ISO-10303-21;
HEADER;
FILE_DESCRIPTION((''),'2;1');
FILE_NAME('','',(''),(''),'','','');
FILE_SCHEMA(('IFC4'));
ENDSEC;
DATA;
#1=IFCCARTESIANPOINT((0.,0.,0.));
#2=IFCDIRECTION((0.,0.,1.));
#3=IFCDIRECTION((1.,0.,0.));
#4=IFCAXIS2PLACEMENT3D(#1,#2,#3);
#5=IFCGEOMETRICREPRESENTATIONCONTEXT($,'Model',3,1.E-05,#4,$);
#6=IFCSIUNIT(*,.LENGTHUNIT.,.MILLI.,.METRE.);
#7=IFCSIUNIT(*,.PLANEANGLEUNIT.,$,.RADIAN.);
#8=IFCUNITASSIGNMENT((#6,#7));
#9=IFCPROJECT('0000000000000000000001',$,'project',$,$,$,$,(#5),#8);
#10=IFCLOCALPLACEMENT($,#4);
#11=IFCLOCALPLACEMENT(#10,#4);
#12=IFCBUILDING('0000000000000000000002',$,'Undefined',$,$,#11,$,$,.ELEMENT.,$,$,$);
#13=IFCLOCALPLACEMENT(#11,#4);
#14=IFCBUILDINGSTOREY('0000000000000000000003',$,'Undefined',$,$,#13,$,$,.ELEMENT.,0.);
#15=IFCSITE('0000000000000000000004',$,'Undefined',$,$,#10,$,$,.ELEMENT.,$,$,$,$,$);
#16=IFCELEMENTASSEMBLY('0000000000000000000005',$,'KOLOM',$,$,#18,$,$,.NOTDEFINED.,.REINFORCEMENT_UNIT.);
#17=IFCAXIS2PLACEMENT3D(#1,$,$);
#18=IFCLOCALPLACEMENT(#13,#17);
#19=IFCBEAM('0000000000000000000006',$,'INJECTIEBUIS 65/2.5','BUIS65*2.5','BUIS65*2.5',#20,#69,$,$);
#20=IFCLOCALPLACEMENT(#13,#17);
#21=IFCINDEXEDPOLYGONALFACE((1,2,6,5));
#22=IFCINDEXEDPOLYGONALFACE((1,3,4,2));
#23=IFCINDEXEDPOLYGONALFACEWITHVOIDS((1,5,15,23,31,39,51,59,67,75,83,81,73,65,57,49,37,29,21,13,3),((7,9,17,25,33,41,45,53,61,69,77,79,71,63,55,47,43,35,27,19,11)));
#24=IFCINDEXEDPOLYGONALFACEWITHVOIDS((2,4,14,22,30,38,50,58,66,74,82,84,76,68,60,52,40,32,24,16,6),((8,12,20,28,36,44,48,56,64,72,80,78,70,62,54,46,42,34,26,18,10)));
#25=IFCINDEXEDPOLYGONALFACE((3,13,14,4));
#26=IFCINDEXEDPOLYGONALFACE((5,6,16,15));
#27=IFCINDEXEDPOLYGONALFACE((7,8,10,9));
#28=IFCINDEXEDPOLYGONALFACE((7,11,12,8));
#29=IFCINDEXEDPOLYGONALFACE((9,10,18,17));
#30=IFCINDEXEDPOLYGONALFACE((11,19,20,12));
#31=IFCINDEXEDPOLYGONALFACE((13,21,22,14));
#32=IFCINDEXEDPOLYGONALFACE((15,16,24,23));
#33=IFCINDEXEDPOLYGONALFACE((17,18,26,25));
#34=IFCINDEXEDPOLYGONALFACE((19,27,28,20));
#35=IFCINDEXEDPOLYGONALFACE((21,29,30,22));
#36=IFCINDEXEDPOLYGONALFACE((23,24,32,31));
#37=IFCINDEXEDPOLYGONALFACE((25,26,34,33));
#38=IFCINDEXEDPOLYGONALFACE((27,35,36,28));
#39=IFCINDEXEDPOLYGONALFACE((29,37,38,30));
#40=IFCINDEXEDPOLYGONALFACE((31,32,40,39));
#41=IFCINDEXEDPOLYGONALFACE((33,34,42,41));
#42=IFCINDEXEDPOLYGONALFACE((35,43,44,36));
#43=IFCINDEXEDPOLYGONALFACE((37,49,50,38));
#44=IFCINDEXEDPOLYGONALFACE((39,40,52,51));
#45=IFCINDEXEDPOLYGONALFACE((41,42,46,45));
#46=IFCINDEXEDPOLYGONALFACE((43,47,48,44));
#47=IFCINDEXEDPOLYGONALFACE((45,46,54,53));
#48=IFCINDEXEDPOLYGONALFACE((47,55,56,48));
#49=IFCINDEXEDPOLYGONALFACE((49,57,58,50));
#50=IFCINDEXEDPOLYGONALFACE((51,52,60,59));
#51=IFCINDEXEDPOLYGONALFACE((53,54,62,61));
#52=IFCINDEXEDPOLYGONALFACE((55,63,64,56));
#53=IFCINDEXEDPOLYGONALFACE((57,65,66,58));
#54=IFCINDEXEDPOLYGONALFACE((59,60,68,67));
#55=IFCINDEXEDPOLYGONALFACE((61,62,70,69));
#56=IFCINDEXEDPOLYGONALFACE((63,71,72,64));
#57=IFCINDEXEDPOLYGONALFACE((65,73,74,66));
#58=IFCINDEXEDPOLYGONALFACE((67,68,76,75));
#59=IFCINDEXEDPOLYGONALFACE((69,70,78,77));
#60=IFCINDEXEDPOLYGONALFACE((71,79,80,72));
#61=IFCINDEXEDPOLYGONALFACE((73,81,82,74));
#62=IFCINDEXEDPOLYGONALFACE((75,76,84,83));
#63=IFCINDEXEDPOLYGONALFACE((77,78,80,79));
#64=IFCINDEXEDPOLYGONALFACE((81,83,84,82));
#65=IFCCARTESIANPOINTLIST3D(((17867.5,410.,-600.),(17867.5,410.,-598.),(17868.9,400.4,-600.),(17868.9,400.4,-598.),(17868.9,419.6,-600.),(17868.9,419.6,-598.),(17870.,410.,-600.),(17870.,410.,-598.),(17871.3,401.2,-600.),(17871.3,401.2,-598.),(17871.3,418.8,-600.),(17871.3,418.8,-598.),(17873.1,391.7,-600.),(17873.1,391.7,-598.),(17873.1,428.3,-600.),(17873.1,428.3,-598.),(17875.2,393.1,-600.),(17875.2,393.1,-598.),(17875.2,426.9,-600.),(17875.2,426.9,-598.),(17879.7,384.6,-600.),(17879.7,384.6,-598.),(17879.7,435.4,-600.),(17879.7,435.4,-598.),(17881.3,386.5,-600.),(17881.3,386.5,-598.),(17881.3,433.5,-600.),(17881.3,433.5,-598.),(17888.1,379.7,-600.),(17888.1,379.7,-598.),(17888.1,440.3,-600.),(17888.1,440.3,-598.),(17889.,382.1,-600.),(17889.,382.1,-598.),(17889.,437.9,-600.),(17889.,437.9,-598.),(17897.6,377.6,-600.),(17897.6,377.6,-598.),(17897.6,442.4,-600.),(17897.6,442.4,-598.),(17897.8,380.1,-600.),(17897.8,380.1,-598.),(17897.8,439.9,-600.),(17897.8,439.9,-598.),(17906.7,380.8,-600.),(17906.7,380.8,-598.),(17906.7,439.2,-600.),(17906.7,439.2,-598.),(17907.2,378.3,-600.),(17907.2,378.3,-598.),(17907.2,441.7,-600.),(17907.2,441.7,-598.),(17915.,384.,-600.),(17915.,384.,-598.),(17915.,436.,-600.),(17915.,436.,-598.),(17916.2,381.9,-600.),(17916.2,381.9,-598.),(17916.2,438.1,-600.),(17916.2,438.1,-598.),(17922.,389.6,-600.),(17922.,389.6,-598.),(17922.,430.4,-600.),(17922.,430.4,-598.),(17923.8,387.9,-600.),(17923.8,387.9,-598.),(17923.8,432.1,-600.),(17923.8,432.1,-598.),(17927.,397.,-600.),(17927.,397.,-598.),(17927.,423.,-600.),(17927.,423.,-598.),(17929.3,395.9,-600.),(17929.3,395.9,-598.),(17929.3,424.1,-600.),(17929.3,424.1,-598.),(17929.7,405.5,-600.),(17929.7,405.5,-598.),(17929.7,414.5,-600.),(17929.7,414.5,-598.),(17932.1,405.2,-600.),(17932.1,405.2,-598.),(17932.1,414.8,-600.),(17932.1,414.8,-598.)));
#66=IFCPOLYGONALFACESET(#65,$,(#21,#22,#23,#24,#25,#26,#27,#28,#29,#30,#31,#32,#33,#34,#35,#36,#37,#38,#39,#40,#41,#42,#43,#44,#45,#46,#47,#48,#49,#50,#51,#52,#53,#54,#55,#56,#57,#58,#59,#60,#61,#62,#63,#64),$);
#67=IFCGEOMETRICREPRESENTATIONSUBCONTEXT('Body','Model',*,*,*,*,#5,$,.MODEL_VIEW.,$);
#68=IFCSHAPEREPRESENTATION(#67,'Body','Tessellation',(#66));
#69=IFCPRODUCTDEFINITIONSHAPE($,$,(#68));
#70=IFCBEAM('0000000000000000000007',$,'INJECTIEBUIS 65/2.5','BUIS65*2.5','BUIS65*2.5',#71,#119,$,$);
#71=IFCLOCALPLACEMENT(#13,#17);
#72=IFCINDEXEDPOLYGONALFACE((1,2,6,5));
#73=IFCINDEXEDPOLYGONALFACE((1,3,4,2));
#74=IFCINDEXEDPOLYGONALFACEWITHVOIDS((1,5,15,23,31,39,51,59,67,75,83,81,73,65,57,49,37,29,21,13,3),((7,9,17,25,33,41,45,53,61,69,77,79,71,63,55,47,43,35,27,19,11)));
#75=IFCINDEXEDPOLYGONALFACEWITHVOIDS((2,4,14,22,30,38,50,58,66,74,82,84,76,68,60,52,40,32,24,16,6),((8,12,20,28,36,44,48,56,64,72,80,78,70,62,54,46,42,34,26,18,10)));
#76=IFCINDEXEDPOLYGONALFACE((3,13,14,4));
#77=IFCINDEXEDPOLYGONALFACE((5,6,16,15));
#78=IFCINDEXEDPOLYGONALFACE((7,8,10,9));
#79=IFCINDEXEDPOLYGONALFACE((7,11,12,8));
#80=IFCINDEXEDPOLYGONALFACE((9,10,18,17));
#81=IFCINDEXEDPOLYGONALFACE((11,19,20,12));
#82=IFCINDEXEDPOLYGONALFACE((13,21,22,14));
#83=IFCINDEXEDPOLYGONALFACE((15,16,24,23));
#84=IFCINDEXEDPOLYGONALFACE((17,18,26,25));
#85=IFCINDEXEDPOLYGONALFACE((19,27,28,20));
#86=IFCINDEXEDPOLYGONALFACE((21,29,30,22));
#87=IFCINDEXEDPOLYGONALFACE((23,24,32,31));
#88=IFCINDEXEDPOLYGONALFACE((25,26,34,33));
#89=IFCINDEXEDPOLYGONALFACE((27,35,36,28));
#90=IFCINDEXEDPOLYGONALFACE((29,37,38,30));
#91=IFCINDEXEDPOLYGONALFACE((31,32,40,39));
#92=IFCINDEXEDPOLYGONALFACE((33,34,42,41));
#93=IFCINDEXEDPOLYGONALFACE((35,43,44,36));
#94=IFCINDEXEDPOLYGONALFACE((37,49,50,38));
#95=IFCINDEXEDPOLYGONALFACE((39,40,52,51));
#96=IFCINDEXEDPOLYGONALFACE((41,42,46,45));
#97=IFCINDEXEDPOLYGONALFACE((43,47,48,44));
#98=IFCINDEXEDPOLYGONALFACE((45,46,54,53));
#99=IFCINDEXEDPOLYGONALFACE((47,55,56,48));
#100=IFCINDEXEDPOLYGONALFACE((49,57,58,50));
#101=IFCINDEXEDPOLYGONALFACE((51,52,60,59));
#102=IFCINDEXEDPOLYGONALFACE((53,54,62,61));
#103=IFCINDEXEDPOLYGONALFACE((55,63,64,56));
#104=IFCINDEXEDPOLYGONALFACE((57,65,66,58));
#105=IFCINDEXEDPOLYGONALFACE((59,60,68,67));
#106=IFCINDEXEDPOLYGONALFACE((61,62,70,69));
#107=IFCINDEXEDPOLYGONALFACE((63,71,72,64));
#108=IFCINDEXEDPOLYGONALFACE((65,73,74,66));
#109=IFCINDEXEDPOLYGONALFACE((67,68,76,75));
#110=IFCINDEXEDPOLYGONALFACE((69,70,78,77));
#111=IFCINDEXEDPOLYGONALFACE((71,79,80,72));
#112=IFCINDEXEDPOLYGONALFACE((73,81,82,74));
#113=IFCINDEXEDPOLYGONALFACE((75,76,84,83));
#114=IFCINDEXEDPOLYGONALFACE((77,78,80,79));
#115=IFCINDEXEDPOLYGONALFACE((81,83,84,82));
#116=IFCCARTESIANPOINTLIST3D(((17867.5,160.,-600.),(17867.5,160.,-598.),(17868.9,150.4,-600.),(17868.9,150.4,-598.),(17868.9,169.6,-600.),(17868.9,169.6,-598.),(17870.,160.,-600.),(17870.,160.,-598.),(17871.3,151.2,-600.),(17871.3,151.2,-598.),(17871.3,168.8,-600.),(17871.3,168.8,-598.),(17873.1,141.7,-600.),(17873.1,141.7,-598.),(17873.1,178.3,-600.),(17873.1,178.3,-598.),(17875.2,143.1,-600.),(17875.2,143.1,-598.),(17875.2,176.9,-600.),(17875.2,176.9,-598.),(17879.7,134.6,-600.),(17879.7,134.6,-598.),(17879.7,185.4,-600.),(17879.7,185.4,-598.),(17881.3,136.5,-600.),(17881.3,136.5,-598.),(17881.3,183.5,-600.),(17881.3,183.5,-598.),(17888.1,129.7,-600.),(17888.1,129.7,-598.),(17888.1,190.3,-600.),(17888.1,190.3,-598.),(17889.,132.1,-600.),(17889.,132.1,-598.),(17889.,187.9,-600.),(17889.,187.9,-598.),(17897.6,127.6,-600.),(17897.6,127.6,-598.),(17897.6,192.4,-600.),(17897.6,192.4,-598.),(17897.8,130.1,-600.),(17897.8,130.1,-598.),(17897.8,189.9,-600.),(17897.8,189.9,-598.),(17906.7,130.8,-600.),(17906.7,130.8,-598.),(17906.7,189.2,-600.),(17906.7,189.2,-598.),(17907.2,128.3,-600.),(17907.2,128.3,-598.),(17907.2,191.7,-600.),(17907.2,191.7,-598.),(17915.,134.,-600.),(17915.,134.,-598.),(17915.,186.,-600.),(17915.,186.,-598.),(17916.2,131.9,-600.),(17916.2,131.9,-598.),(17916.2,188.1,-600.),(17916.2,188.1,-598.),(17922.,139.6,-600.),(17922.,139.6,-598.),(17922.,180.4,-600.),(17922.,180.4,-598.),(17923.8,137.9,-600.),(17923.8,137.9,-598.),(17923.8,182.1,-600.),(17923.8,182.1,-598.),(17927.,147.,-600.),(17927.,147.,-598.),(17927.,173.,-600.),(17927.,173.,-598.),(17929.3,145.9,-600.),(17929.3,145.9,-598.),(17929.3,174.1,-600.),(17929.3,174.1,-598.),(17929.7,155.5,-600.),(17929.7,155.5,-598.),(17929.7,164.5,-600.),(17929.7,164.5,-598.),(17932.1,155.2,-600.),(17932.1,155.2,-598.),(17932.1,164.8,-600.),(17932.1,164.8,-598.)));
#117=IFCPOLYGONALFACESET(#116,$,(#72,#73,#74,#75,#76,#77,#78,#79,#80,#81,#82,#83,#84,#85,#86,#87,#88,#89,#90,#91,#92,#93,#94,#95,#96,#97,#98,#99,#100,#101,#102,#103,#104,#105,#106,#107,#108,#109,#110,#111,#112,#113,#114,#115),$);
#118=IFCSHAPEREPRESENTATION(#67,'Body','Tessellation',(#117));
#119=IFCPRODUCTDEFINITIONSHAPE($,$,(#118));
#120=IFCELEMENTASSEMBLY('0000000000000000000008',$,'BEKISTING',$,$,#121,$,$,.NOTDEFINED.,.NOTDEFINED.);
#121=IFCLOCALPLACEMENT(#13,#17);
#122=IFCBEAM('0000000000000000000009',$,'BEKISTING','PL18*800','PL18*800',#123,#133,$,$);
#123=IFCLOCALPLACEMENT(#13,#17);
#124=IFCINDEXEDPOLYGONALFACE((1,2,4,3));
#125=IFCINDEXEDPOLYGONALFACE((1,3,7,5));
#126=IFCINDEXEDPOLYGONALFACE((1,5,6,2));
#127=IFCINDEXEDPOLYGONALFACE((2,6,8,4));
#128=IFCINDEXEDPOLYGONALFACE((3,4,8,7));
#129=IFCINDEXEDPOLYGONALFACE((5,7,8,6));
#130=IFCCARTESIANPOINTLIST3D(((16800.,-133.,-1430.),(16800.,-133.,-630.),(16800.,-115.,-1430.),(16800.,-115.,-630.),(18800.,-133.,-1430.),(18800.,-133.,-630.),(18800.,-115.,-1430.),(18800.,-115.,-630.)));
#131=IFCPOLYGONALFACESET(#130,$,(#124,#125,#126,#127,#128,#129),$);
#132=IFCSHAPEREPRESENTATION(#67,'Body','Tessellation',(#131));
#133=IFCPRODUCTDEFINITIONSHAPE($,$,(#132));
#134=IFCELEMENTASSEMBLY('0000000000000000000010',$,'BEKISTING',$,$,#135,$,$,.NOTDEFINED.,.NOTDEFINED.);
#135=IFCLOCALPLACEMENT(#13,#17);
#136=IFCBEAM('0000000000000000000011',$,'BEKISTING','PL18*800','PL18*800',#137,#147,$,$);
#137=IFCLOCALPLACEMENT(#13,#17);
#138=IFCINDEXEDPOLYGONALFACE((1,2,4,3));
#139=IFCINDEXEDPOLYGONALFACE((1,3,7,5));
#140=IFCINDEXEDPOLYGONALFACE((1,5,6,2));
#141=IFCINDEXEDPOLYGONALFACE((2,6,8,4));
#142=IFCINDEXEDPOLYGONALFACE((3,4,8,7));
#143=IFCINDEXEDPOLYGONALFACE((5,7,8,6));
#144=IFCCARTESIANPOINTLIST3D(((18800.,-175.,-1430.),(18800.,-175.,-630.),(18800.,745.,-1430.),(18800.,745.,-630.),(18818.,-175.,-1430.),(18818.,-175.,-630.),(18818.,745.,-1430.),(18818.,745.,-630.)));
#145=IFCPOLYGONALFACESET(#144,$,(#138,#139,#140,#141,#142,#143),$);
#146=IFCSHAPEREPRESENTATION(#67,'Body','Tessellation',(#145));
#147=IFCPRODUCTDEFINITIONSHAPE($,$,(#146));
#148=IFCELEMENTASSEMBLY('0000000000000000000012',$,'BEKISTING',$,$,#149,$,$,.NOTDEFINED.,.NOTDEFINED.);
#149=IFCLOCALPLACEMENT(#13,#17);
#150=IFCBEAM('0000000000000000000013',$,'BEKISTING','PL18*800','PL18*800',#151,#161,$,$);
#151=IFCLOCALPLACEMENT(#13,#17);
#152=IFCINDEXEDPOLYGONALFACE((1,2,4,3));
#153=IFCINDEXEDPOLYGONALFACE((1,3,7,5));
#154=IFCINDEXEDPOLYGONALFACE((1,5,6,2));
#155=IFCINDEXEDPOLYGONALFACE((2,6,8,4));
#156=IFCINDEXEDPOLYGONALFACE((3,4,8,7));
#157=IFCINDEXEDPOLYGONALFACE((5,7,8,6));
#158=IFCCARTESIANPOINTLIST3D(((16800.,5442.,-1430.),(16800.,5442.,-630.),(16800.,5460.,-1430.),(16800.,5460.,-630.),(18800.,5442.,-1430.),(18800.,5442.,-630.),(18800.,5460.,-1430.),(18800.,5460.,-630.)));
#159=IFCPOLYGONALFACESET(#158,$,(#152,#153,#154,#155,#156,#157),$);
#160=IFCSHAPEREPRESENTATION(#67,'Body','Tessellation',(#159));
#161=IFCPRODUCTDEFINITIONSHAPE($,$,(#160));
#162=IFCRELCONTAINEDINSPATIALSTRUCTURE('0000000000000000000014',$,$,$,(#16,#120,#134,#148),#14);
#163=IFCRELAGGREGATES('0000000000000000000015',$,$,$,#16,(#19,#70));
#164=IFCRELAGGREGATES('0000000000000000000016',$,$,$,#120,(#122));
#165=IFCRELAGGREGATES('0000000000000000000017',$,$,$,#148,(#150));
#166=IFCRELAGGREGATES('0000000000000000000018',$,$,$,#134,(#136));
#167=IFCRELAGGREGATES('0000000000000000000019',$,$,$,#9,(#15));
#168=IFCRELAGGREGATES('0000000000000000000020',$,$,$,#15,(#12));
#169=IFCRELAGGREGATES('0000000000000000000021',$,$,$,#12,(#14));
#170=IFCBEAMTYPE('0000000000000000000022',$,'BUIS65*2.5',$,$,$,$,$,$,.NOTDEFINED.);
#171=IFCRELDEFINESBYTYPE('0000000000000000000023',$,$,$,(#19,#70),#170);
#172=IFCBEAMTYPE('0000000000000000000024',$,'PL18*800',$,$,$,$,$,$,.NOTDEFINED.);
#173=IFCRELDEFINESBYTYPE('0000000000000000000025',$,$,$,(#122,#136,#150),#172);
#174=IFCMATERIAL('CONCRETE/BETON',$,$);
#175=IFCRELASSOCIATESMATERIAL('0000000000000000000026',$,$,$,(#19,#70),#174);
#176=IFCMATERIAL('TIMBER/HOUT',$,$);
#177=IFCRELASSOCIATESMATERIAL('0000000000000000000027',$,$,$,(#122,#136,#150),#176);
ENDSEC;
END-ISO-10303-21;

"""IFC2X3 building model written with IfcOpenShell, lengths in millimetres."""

from ifc_helpers import new_model, si_unit, frame, frame_2d, origin_with_axes, place, context, subcontext, project, spatial, rectangle, hollow_circle, extrude, material, type_object, element, aggregate, save


model = new_model("IFC2X3")

# Units and contexts
model_context = context("Model", 3, precision=1e-05, world=origin_with_axes())
body_context = subcontext(model_context, "Body", "Model", "MODEL_VIEW")
ifc_project = project(units=[si_unit("LENGTHUNIT", "METRE", prefix="MILLI"), si_unit("PLANEANGLEUNIT", "RADIAN")], contexts=[model_context])

# Site, building, storey
site_placement = place(None, origin_with_axes())
site = spatial("IfcSite", under=ifc_project, at=site_placement, Name="Undefined", CompositionType="ELEMENT")
building_placement = place(site_placement, origin_with_axes())
building = spatial("IfcBuilding", under=site, at=building_placement, Name="Undefined", CompositionType="ELEMENT")
storey_placement = place(building_placement, origin_with_axes())
storey = spatial("IfcBuildingStorey", under=building, at=storey_placement, Name="Undefined", CompositionType="ELEMENT", Elevation=0.0)

# Shared definitions
ifc_material_1 = material(Name="CONCRETE/BETON")

# Element assembly, beams
assembly_1_placement = place(storey_placement, origin_with_axes())
assembly_1 = element("IfcElementAssembly", 1, at=assembly_1_placement, inside=storey, Name="KOLOM", AssemblyPlace="NOTDEFINED", PredefinedType="REINFORCEMENT_UNIT")
beam_type_1 = type_object("IfcBeamType", Name="BUIS65*2.5", PredefinedType="NOTDEFINED")
beam_1_placement = place(assembly_1_placement, frame((17900.0, 410.0, -600.0), z_axis=(0.0, 1.0, 0.0), x_axis=(0.0, 0.0, 1.0)))
beam_1 = element("IfcBeam", 2, at=beam_1_placement, type_object=beam_type_1, material=ifc_material_1, Name="INJECTIEBUIS 65/2.5", Description="BUIS65*2.5", ObjectType="BUIS65*2.5", context=body_context, shape_type="SweptSolid", body=[
    extrude(hollow_circle(Radius=32.5, WallThickness=2.5, at=frame_2d((0.0, 0.0), x_axis=(1.0, 0.0))), frame((2.0, 0.0, 0.0), z_axis=(-1.0, 0.0, 0.0), x_axis=(0.0, -1.0, 0.0)), (0.0, 0.0, 1.0), 2.0),
])
beam_2_placement = place(assembly_1_placement, frame((17900.0, 160.0, -600.0), z_axis=(0.0, 1.0, 0.0), x_axis=(0.0, 0.0, 1.0)))
beam_2 = element("IfcBeam", 3, at=beam_2_placement, type_object=beam_type_1, material=ifc_material_1, Name="INJECTIEBUIS 65/2.5", Description="BUIS65*2.5", ObjectType="BUIS65*2.5", context=body_context, shape_type="SweptSolid", body=[
    extrude(hollow_circle(Radius=32.5, WallThickness=2.5, at=frame_2d((0.0, 0.0), x_axis=(1.0, 0.0))), frame((2.0, 0.0, 0.0), z_axis=(-1.0, 0.0, 0.0), x_axis=(0.0, -1.0, 0.0)), (0.0, 0.0, 1.0), 2.0),
])
aggregate(assembly_1, [beam_1, beam_2])

# Element assemblies, beams
assembly_2_placement = place(storey_placement, origin_with_axes())
assembly_2 = element("IfcElementAssembly", 4, at=assembly_2_placement, inside=storey, Name="BEKISTING", AssemblyPlace="NOTDEFINED", PredefinedType="NOTDEFINED")
ifc_material_2 = material(Name="TIMBER/HOUT")
beam_type_2 = type_object("IfcBeamType", Name="PL18*800", PredefinedType="NOTDEFINED")
beam_3_placement = place(assembly_2_placement, frame((18800.0, -124.0, -1030.0), z_axis=(0.0, 0.0, -1.0), x_axis=(-1.0, 0.0, 0.0)))
beam_3 = element("IfcBeam", 5, at=beam_3_placement, type_object=beam_type_2, material=ifc_material_2, Name="BEKISTING", Description="PL18*800", ObjectType="PL18*800", context=body_context, shape_type="SweptSolid", body=[
    extrude(rectangle(XDim=18.0, YDim=800.0, at=frame_2d((0.0, 0.0), x_axis=(1.0, 0.0))), frame((2000.0, 0.0, 0.0), z_axis=(-1.0, 0.0, 0.0), x_axis=(0.0, -1.0, 0.0)), (0.0, 0.0, 1.0), 2000.0),
])
aggregate(assembly_2, [beam_3])
assembly_3_placement = place(storey_placement, origin_with_axes())
assembly_3 = element("IfcElementAssembly", 6, at=assembly_3_placement, inside=storey, Name="BEKISTING", AssemblyPlace="NOTDEFINED", PredefinedType="NOTDEFINED")
beam_4_placement = place(assembly_3_placement, frame((18809.0, 745.0, -1030.0), z_axis=(0.0, 0.0, 1.0), x_axis=(0.0, -1.0, 0.0)))
beam_4 = element("IfcBeam", 7, at=beam_4_placement, type_object=beam_type_2, material=ifc_material_2, Name="BEKISTING", Description="PL18*800", ObjectType="PL18*800", context=body_context, shape_type="SweptSolid", body=[
    extrude(rectangle(XDim=18.0, YDim=800.0, at=frame_2d((0.0, 0.0), x_axis=(1.0, 0.0))), frame((920.0, 0.0, 0.0), z_axis=(-1.0, 0.0, 0.0), x_axis=(0.0, -1.0, 0.0)), (0.0, 0.0, 1.0), 920.0),
])
assembly_4_placement = place(storey_placement, origin_with_axes())
assembly_4 = element("IfcElementAssembly", 8, at=assembly_4_placement, inside=storey, Name="BEKISTING", AssemblyPlace="NOTDEFINED", PredefinedType="NOTDEFINED")
beam_5_placement = place(assembly_4_placement, frame((18800.0, 5451.0, -1030.0), z_axis=(0.0, 0.0, -1.0), x_axis=(-1.0, 0.0, 0.0)))
beam_5 = element("IfcBeam", 9, at=beam_5_placement, type_object=beam_type_2, material=ifc_material_2, Name="BEKISTING", Description="PL18*800", ObjectType="PL18*800", context=body_context, shape_type="SweptSolid", body=[
    extrude(rectangle(XDim=18.0, YDim=800.0, at=frame_2d((0.0, 0.0), x_axis=(1.0, 0.0))), frame((2000.0, 0.0, 0.0), z_axis=(-1.0, 0.0, 0.0), x_axis=(0.0, -1.0, 0.0)), (0.0, 0.0, 1.0), 2000.0),
])
aggregate(assembly_4, [beam_5])

aggregate(assembly_3, [beam_4])

save(model, "model.ifc")
